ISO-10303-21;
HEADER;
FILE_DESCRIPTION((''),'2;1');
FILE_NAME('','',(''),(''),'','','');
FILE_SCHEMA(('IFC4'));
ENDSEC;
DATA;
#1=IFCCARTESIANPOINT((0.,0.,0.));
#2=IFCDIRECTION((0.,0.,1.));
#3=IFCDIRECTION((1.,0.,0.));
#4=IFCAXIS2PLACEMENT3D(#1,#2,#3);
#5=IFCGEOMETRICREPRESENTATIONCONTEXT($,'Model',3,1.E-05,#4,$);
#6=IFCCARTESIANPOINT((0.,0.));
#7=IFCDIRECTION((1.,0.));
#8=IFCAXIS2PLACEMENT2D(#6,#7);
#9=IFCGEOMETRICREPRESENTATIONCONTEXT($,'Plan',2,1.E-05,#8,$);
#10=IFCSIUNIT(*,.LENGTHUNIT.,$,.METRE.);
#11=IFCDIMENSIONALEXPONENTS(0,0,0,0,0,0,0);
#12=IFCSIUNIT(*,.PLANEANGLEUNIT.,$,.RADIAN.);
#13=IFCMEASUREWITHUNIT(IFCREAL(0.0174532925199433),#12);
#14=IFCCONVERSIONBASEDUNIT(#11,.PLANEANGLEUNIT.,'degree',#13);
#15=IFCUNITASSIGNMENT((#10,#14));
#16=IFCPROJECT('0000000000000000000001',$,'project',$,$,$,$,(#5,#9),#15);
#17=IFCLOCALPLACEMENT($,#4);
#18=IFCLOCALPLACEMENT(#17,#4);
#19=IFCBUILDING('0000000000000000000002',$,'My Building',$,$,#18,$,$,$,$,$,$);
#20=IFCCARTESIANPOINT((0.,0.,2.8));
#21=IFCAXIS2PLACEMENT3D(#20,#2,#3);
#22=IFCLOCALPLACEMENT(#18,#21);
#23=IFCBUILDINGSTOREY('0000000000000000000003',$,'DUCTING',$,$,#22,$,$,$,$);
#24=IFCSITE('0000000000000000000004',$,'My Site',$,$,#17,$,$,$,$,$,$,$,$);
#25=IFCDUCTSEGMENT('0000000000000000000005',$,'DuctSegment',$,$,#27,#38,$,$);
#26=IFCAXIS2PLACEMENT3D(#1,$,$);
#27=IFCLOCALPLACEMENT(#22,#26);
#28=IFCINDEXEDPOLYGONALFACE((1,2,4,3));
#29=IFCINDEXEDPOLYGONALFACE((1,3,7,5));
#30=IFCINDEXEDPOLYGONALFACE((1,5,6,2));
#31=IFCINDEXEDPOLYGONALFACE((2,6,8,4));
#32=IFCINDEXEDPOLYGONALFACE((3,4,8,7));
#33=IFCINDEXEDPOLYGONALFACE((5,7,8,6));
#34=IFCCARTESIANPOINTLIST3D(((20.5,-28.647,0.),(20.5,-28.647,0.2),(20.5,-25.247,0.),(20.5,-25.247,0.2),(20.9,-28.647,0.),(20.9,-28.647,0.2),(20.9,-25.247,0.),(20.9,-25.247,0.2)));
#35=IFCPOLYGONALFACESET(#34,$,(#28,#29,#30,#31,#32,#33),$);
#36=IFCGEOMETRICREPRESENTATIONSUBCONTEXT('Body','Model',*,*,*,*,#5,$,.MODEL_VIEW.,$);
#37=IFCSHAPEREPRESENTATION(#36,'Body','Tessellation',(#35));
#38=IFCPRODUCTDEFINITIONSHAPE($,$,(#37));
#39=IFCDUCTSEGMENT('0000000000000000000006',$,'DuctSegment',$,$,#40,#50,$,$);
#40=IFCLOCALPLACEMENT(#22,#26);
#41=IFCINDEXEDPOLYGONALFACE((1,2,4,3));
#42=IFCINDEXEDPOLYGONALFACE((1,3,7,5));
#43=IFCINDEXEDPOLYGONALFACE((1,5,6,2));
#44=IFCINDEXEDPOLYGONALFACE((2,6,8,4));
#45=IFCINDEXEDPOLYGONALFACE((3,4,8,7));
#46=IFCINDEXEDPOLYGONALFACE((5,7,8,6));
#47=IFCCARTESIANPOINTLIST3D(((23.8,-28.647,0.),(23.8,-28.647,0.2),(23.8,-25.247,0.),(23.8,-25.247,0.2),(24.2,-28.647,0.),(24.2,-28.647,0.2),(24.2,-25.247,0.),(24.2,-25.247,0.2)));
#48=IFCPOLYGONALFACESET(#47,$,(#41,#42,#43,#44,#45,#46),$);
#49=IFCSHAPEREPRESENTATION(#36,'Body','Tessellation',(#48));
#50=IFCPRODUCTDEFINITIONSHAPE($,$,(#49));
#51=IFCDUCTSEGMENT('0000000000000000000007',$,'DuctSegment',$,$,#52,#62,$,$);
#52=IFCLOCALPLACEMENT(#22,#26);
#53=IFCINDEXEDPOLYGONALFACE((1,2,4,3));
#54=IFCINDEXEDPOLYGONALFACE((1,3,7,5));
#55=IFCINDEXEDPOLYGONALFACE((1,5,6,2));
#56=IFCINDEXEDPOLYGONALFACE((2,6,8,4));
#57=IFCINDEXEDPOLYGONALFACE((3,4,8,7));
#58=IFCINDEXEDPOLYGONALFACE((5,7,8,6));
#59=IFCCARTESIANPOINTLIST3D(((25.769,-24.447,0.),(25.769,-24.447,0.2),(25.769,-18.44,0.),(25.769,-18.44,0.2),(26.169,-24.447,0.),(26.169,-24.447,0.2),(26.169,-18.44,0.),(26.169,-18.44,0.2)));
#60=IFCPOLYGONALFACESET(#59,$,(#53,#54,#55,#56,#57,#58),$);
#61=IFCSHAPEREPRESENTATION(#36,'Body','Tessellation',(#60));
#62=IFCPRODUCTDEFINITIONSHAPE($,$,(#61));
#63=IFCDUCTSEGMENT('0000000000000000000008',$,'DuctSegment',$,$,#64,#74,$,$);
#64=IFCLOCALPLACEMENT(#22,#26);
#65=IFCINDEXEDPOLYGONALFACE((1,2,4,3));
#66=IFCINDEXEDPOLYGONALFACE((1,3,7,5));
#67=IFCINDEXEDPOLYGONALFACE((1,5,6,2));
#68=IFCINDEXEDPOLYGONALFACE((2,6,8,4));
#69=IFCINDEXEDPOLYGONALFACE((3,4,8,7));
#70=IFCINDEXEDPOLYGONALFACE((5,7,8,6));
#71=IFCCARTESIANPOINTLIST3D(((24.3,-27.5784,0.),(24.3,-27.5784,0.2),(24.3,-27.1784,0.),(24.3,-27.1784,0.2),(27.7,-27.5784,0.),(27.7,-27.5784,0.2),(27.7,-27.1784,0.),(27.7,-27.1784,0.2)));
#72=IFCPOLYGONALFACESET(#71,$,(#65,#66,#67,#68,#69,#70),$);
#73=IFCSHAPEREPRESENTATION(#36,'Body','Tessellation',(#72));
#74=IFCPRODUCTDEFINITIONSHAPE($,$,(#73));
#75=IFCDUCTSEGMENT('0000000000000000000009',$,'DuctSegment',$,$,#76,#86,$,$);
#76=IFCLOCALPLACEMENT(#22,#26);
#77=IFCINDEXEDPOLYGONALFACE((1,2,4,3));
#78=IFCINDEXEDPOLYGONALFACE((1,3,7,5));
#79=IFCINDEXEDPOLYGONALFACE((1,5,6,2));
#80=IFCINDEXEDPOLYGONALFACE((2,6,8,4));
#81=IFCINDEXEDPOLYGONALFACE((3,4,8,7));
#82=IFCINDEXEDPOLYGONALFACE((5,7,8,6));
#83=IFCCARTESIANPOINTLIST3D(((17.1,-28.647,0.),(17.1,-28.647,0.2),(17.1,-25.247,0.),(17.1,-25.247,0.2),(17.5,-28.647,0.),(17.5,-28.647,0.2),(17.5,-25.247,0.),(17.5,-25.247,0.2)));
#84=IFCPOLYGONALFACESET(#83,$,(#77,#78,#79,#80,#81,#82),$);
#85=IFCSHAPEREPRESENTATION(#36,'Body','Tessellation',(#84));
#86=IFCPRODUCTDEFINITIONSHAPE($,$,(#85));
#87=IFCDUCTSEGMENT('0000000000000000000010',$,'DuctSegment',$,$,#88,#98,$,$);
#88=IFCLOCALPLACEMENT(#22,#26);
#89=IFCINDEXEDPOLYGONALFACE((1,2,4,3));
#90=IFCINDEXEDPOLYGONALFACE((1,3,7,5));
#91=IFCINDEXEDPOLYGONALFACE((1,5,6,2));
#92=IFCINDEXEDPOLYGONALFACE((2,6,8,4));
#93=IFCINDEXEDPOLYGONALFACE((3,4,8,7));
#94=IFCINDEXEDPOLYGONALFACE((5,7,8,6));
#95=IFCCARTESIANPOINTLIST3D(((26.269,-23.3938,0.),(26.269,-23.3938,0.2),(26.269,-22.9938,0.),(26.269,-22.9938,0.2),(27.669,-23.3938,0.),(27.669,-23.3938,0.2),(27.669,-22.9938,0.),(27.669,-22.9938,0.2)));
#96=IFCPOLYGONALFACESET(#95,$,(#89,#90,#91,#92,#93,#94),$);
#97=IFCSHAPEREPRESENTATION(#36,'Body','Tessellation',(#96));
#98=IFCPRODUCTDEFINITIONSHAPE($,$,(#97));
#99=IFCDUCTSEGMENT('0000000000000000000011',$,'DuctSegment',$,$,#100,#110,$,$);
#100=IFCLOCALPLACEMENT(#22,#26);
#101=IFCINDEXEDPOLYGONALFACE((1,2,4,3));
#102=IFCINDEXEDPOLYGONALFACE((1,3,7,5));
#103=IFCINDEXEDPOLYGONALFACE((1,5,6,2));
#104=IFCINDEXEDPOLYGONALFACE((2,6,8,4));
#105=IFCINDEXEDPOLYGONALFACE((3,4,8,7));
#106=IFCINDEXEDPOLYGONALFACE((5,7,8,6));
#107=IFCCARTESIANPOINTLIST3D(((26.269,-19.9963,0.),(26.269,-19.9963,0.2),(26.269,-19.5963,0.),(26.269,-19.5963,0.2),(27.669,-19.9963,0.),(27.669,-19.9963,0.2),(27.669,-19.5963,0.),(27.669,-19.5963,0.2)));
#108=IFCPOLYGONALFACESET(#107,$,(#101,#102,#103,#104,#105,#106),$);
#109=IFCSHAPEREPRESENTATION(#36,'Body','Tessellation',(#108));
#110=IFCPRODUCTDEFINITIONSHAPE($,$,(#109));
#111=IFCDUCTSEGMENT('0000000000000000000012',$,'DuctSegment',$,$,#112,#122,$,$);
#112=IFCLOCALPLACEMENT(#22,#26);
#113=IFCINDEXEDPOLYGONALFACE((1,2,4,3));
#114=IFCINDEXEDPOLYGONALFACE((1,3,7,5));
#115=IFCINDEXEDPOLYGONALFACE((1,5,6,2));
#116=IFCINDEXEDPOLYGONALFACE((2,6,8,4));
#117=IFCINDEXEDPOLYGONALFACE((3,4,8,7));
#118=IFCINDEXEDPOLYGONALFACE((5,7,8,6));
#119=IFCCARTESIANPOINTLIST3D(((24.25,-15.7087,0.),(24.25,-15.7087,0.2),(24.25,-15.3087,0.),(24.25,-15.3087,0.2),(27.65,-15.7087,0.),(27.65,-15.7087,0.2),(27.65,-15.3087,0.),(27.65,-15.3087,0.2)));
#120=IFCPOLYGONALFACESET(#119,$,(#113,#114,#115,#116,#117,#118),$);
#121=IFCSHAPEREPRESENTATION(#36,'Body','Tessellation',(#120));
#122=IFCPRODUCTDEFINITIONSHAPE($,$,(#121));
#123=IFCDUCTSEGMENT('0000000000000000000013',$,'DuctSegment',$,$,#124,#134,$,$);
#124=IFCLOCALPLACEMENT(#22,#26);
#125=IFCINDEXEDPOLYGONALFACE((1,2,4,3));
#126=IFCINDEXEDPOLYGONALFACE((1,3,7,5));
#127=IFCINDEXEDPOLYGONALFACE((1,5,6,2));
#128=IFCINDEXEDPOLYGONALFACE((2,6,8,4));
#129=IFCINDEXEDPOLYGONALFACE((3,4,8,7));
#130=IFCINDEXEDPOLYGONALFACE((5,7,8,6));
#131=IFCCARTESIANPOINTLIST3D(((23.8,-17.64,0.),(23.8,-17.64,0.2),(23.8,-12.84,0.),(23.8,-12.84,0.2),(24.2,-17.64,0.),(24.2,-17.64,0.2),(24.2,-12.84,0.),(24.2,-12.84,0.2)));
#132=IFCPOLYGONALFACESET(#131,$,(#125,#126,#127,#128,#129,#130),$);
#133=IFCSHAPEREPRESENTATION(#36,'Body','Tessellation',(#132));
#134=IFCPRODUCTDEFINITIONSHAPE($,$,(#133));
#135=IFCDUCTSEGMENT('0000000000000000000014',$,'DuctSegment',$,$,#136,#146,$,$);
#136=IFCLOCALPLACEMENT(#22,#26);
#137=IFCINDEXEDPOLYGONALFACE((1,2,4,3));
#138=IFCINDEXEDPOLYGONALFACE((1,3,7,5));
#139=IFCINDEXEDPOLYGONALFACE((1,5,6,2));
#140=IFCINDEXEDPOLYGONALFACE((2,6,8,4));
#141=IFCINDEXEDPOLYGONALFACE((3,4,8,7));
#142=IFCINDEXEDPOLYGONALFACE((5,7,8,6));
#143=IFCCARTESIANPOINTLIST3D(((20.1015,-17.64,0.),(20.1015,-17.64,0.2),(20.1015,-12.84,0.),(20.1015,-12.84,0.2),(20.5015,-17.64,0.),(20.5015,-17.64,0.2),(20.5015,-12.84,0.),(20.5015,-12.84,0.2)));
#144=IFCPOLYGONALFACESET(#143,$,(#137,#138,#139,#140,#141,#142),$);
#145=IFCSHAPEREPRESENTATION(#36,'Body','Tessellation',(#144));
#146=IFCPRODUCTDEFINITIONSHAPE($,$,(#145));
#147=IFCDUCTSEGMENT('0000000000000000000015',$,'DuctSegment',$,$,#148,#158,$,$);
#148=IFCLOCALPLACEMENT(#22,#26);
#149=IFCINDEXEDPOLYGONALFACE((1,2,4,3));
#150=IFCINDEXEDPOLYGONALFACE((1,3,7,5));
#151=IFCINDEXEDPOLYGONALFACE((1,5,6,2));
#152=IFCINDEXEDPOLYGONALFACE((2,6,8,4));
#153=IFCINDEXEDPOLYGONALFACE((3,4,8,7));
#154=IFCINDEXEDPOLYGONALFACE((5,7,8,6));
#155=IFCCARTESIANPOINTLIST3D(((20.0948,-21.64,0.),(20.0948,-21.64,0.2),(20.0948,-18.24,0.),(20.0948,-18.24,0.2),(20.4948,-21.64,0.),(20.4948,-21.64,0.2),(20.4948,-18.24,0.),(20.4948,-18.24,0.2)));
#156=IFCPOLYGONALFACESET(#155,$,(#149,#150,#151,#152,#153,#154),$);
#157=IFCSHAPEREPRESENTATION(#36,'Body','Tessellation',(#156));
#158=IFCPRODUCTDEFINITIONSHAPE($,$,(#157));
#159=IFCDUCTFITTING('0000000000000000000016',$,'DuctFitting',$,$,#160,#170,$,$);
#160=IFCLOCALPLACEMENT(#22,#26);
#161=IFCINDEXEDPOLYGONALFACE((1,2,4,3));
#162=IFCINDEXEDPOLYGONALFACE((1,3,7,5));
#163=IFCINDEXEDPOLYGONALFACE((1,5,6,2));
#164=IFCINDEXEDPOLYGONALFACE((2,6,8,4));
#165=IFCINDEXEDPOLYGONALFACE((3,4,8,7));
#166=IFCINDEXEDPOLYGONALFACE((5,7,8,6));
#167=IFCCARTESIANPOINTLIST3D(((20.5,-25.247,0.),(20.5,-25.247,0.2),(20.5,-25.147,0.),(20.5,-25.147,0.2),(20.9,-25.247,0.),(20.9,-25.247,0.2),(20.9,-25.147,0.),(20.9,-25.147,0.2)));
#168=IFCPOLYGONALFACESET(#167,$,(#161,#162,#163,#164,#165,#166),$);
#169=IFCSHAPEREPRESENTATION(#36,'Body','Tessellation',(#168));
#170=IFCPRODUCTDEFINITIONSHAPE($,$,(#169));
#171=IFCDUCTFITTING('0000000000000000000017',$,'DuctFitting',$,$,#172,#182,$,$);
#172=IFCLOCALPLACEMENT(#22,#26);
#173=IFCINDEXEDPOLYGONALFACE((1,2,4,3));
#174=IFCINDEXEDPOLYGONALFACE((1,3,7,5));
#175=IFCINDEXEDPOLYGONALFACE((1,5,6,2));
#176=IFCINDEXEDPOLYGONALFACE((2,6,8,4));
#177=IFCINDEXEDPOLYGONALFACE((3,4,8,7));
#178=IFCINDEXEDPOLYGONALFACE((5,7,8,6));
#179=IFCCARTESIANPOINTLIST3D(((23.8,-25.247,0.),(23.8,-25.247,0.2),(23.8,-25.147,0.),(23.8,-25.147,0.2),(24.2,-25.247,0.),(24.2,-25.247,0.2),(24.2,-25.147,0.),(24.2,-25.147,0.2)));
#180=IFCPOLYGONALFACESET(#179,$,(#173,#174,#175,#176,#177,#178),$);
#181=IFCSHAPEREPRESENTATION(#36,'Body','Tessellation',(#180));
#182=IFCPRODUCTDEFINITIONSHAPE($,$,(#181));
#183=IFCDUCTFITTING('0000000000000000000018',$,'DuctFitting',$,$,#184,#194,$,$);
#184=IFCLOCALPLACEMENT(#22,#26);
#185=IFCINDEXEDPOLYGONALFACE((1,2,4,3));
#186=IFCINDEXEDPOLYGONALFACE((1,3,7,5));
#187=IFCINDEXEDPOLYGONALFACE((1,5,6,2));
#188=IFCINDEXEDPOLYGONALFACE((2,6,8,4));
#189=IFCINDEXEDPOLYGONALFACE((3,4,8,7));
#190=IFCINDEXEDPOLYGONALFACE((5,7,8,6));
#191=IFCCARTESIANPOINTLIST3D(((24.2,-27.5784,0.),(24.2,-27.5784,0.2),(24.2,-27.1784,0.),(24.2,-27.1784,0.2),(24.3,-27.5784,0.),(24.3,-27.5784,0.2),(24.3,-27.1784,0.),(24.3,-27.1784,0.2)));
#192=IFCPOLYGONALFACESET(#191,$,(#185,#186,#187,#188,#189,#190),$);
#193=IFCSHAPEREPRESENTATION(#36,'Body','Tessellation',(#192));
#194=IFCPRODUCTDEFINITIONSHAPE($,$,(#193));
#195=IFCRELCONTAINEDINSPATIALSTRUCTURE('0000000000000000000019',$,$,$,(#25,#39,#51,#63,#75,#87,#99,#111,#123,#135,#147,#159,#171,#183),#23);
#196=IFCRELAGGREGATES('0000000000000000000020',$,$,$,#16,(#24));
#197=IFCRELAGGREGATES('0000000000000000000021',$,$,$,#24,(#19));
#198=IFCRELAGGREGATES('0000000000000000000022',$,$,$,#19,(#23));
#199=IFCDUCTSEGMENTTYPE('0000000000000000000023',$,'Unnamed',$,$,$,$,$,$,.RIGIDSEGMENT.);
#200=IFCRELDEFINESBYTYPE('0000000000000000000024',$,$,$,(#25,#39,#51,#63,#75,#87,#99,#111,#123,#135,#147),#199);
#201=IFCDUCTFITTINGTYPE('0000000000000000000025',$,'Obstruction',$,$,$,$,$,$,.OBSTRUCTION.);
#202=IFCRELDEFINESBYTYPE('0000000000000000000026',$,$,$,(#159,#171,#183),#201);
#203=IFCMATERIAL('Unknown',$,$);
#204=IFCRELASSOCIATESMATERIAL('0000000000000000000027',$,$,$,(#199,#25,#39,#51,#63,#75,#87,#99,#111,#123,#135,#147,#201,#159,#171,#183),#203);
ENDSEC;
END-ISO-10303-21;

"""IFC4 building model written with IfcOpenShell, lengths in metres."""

from ifc_helpers import new_model, entity, si_unit, converted_unit, frame, origin_with_axes, origin_2d_with_axis, place, context, subcontext, project, spatial, rectangle, extrude, material, material_profile, profile_set, profile_usage, type_object, element, save


model = new_model("IFC4")

# Units and contexts
model_context = context("Model", 3, precision=1e-05, world=origin_with_axes())
plan_context = context("Plan", 2, precision=1e-05, world=origin_2d_with_axis())
body_context = subcontext(model_context, "Body", "Model", "MODEL_VIEW")
ifc_project = project(units=[si_unit("LENGTHUNIT", "METRE"), converted_unit("PLANEANGLEUNIT", "degree", entity("IfcReal", 0.0174532925199433), si_unit("PLANEANGLEUNIT", "RADIAN"), dimensions=[0, 0, 0, 0, 0, 0, 0])], contexts=[model_context, plan_context])

# Site, building, storey
site_placement = place(None, origin_with_axes())
site = spatial("IfcSite", under=ifc_project, at=site_placement, Name="My Site")
building_placement = place(site_placement, origin_with_axes())
building = spatial("IfcBuilding", under=site, at=building_placement, Name="My Building")
storey_placement = place(building_placement, frame((0.0, 0.0, 2.8), z_axis=(0.0, 0.0, 1.0), x_axis=(1.0, 0.0, 0.0)))
storey = spatial("IfcBuildingStorey", under=building, at=storey_placement, Name="DUCTING")

# Duct segments
ifc_material = material(Name="Unknown")
ifc_material_profile_1 = material_profile(ifc_material, rectangle(XDim=0.4, YDim=0.2))
ifc_profile_set_1 = profile_set([ifc_material_profile_1])
ifc_profile_usage_1 = profile_usage(ifc_profile_set_1, cardinal=5)
duct_segment_type = type_object("IfcDuctSegmentType", Name="Unnamed", PredefinedType="RIGIDSEGMENT", material=ifc_profile_set_1)
duct_segment_1_placement = place(storey_placement, frame((20.7, -25.247, 0.1), z_axis=(0.0, -1.0, -0.000004), x_axis=(1.0, 0.0, 0.0)))
element("IfcDuctSegment", 1, at=duct_segment_1_placement, inside=storey, type_object=duct_segment_type, material=ifc_profile_usage_1, Name="DuctSegment", context=body_context, shape_type="SweptSolid", body=[
    extrude(rectangle(XDim=0.4, YDim=0.2), origin_with_axes(), (0.0, 0.0, 1.0), 3.4),
])
ifc_profile_usage_2 = profile_usage(ifc_profile_set_1, cardinal=5)
duct_segment_2_placement = place(storey_placement, frame((24.0, -25.247, 0.1), z_axis=(0.0, -1.0, -0.000004), x_axis=(1.0, 0.0, 0.0)))
element("IfcDuctSegment", 2, at=duct_segment_2_placement, inside=storey, type_object=duct_segment_type, material=ifc_profile_usage_2, Name="DuctSegment", context=body_context, shape_type="SweptSolid", body=[
    extrude(rectangle(XDim=0.4, YDim=0.2), origin_with_axes(), (0.0, 0.0, 1.0), 3.4),
])
ifc_profile_usage_3 = profile_usage(ifc_profile_set_1, cardinal=5)
duct_segment_3_placement = place(storey_placement, frame((25.969, -24.447, 0.1), z_axis=(0.0, 1.0, 0.0), x_axis=(-1.0, 0.0, 0.0)))
element("IfcDuctSegment", 3, at=duct_segment_3_placement, inside=storey, type_object=duct_segment_type, material=ifc_profile_usage_3, Name="DuctSegment", context=body_context, shape_type="SweptSolid", body=[
    extrude(rectangle(XDim=0.4, YDim=0.2), origin_with_axes(), (0.0, 0.0, 1.0), 6.007),
])
ifc_profile_usage_4 = profile_usage(ifc_profile_set_1, cardinal=5)
duct_segment_4_placement = place(storey_placement, frame((24.3, -27.3784, 0.1), z_axis=(1.0, 0.0, -0.000004), x_axis=(0.0, 1.0, 0.0)))
element("IfcDuctSegment", 4, at=duct_segment_4_placement, inside=storey, type_object=duct_segment_type, material=ifc_profile_usage_4, Name="DuctSegment", context=body_context, shape_type="SweptSolid", body=[
    extrude(rectangle(XDim=0.4, YDim=0.2), origin_with_axes(), (0.0, 0.0, 1.0), 3.4),
])
ifc_profile_usage_5 = profile_usage(ifc_profile_set_1, cardinal=5)
duct_segment_5_placement = place(storey_placement, frame((17.3, -25.247, 0.1), z_axis=(0.0, -1.0, -0.000004), x_axis=(1.0, 0.0, 0.0)))
element("IfcDuctSegment", 5, at=duct_segment_5_placement, inside=storey, type_object=duct_segment_type, material=ifc_profile_usage_5, Name="DuctSegment", context=body_context, shape_type="SweptSolid", body=[
    extrude(rectangle(XDim=0.4, YDim=0.2), origin_with_axes(), (0.0, 0.0, 1.0), 3.4),
])
ifc_profile_usage_6 = profile_usage(ifc_profile_set_1, cardinal=5)
duct_segment_6_placement = place(storey_placement, frame((27.669, -23.1938, 0.1), z_axis=(-1.0, 0.0, 0.0), x_axis=(0.0, -1.0, 0.0)))
element("IfcDuctSegment", 6, at=duct_segment_6_placement, inside=storey, type_object=duct_segment_type, material=ifc_profile_usage_6, Name="DuctSegment", context=body_context, shape_type="SweptSolid", body=[
    extrude(rectangle(XDim=0.4, YDim=0.2), origin_with_axes(), (0.0, 0.0, 1.0), 1.4),
])
ifc_profile_usage_7 = profile_usage(ifc_profile_set_1, cardinal=5)
duct_segment_7_placement = place(storey_placement, frame((27.669, -19.7963, 0.1), z_axis=(-1.0, 0.0, 0.0), x_axis=(0.0, -1.0, 0.0)))
element("IfcDuctSegment", 7, at=duct_segment_7_placement, inside=storey, type_object=duct_segment_type, material=ifc_profile_usage_7, Name="DuctSegment", context=body_context, shape_type="SweptSolid", body=[
    extrude(rectangle(XDim=0.4, YDim=0.2), origin_with_axes(), (0.0, 0.0, 1.0), 1.4),
])
ifc_profile_usage_8 = profile_usage(ifc_profile_set_1, cardinal=5)
duct_segment_8_placement = place(storey_placement, frame((24.25, -15.5087, 0.1), z_axis=(1.0, 0.0, -0.000004), x_axis=(0.0, 1.0, 0.0)))
element("IfcDuctSegment", 8, at=duct_segment_8_placement, inside=storey, type_object=duct_segment_type, material=ifc_profile_usage_8, Name="DuctSegment", context=body_context, shape_type="SweptSolid", body=[
    extrude(rectangle(XDim=0.4, YDim=0.2), origin_with_axes(), (0.0, 0.0, 1.0), 3.4),
])
ifc_profile_usage_9 = profile_usage(ifc_profile_set_1, cardinal=5)
duct_segment_9_placement = place(storey_placement, frame((24.0, -17.64, 0.1), z_axis=(0.0, 1.0, 0.0), x_axis=(-1.0, 0.0, 0.0)))
element("IfcDuctSegment", 9, at=duct_segment_9_placement, inside=storey, type_object=duct_segment_type, material=ifc_profile_usage_9, Name="DuctSegment", context=body_context, shape_type="SweptSolid", body=[
    extrude(rectangle(XDim=0.4, YDim=0.2), origin_with_axes(), (0.0, 0.0, 1.0), 4.8),
])
ifc_profile_usage_10 = profile_usage(ifc_profile_set_1, cardinal=5)
duct_segment_10_placement = place(storey_placement, frame((20.3015, -17.64, 0.1), z_axis=(0.0, 1.0, 0.0), x_axis=(-1.0, 0.0, 0.0)))
element("IfcDuctSegment", 10, at=duct_segment_10_placement, inside=storey, type_object=duct_segment_type, material=ifc_profile_usage_10, Name="DuctSegment", context=body_context, shape_type="SweptSolid", body=[
    extrude(rectangle(XDim=0.4, YDim=0.2), origin_with_axes(), (0.0, 0.0, 1.0), 4.8),
])
ifc_profile_usage_11 = profile_usage(ifc_profile_set_1, cardinal=5)
duct_segment_11_placement = place(storey_placement, frame((20.2948, -18.24, 0.1), z_axis=(0.0, -1.0, -0.000004), x_axis=(1.0, 0.0, 0.0)))
element("IfcDuctSegment", 11, at=duct_segment_11_placement, inside=storey, type_object=duct_segment_type, material=ifc_profile_usage_11, Name="DuctSegment", context=body_context, shape_type="SweptSolid", body=[
    extrude(rectangle(XDim=0.4, YDim=0.2), origin_with_axes(), (0.0, 0.0, 1.0), 3.4),
])

# Duct fittings
ifc_material_profile_2 = material_profile(ifc_material, rectangle(XDim=0.4, YDim=0.2))
ifc_profile_set_2 = profile_set([ifc_material_profile_2])
ifc_profile_usage_12 = profile_usage(ifc_profile_set_2, cardinal=5)
duct_fitting_type_1 = type_object("IfcDuctFittingType", Name="Obstruction", PredefinedType="OBSTRUCTION", material=ifc_profile_set_2)
duct_fitting_1_placement = place(storey_placement, frame((20.7, -25.147, 0.1), z_axis=(0.0, -1.0, -0.000004), x_axis=(1.0, 0.0, 0.0)))
element("IfcDuctFitting", 12, at=duct_fitting_1_placement, inside=storey, type_object=duct_fitting_type_1, material=ifc_profile_usage_12, Name="DuctFitting", context=body_context, shape_type="SweptSolid", body=[
    extrude(rectangle(XDim=0.4, YDim=0.2), origin_with_axes(), (0.0, 0.0, 1.0), 0.1),
])
ifc_profile_usage_13 = profile_usage(ifc_profile_set_2, cardinal=5)
duct_fitting_2_placement = place(storey_placement, frame((24.0, -25.147, 0.1), z_axis=(0.0, -1.0, -0.000004), x_axis=(1.0, 0.0, 0.0)))
element("IfcDuctFitting", 13, at=duct_fitting_2_placement, inside=storey, type_object=duct_fitting_type_1, material=ifc_profile_usage_13, Name="DuctFitting", context=body_context, shape_type="SweptSolid", body=[
    extrude(rectangle(XDim=0.4, YDim=0.2), origin_with_axes(), (0.0, 0.0, 1.0), 0.1),
])
ifc_profile_usage_14 = profile_usage(ifc_profile_set_2, cardinal=5)
duct_fitting_3_placement = place(storey_placement, frame((24.2, -27.3784, 0.1), z_axis=(1.0, 0.0, -0.000004), x_axis=(0.0, 1.0, 0.0)))
element("IfcDuctFitting", 14, at=duct_fitting_3_placement, inside=storey, type_object=duct_fitting_type_1, material=ifc_profile_usage_14, Name="DuctFitting", context=body_context, shape_type="SweptSolid", body=[
    extrude(rectangle(XDim=0.4, YDim=0.2), origin_with_axes(), (0.0, 0.0, 1.0), 0.1),
])

save(model, "model.ifc")
